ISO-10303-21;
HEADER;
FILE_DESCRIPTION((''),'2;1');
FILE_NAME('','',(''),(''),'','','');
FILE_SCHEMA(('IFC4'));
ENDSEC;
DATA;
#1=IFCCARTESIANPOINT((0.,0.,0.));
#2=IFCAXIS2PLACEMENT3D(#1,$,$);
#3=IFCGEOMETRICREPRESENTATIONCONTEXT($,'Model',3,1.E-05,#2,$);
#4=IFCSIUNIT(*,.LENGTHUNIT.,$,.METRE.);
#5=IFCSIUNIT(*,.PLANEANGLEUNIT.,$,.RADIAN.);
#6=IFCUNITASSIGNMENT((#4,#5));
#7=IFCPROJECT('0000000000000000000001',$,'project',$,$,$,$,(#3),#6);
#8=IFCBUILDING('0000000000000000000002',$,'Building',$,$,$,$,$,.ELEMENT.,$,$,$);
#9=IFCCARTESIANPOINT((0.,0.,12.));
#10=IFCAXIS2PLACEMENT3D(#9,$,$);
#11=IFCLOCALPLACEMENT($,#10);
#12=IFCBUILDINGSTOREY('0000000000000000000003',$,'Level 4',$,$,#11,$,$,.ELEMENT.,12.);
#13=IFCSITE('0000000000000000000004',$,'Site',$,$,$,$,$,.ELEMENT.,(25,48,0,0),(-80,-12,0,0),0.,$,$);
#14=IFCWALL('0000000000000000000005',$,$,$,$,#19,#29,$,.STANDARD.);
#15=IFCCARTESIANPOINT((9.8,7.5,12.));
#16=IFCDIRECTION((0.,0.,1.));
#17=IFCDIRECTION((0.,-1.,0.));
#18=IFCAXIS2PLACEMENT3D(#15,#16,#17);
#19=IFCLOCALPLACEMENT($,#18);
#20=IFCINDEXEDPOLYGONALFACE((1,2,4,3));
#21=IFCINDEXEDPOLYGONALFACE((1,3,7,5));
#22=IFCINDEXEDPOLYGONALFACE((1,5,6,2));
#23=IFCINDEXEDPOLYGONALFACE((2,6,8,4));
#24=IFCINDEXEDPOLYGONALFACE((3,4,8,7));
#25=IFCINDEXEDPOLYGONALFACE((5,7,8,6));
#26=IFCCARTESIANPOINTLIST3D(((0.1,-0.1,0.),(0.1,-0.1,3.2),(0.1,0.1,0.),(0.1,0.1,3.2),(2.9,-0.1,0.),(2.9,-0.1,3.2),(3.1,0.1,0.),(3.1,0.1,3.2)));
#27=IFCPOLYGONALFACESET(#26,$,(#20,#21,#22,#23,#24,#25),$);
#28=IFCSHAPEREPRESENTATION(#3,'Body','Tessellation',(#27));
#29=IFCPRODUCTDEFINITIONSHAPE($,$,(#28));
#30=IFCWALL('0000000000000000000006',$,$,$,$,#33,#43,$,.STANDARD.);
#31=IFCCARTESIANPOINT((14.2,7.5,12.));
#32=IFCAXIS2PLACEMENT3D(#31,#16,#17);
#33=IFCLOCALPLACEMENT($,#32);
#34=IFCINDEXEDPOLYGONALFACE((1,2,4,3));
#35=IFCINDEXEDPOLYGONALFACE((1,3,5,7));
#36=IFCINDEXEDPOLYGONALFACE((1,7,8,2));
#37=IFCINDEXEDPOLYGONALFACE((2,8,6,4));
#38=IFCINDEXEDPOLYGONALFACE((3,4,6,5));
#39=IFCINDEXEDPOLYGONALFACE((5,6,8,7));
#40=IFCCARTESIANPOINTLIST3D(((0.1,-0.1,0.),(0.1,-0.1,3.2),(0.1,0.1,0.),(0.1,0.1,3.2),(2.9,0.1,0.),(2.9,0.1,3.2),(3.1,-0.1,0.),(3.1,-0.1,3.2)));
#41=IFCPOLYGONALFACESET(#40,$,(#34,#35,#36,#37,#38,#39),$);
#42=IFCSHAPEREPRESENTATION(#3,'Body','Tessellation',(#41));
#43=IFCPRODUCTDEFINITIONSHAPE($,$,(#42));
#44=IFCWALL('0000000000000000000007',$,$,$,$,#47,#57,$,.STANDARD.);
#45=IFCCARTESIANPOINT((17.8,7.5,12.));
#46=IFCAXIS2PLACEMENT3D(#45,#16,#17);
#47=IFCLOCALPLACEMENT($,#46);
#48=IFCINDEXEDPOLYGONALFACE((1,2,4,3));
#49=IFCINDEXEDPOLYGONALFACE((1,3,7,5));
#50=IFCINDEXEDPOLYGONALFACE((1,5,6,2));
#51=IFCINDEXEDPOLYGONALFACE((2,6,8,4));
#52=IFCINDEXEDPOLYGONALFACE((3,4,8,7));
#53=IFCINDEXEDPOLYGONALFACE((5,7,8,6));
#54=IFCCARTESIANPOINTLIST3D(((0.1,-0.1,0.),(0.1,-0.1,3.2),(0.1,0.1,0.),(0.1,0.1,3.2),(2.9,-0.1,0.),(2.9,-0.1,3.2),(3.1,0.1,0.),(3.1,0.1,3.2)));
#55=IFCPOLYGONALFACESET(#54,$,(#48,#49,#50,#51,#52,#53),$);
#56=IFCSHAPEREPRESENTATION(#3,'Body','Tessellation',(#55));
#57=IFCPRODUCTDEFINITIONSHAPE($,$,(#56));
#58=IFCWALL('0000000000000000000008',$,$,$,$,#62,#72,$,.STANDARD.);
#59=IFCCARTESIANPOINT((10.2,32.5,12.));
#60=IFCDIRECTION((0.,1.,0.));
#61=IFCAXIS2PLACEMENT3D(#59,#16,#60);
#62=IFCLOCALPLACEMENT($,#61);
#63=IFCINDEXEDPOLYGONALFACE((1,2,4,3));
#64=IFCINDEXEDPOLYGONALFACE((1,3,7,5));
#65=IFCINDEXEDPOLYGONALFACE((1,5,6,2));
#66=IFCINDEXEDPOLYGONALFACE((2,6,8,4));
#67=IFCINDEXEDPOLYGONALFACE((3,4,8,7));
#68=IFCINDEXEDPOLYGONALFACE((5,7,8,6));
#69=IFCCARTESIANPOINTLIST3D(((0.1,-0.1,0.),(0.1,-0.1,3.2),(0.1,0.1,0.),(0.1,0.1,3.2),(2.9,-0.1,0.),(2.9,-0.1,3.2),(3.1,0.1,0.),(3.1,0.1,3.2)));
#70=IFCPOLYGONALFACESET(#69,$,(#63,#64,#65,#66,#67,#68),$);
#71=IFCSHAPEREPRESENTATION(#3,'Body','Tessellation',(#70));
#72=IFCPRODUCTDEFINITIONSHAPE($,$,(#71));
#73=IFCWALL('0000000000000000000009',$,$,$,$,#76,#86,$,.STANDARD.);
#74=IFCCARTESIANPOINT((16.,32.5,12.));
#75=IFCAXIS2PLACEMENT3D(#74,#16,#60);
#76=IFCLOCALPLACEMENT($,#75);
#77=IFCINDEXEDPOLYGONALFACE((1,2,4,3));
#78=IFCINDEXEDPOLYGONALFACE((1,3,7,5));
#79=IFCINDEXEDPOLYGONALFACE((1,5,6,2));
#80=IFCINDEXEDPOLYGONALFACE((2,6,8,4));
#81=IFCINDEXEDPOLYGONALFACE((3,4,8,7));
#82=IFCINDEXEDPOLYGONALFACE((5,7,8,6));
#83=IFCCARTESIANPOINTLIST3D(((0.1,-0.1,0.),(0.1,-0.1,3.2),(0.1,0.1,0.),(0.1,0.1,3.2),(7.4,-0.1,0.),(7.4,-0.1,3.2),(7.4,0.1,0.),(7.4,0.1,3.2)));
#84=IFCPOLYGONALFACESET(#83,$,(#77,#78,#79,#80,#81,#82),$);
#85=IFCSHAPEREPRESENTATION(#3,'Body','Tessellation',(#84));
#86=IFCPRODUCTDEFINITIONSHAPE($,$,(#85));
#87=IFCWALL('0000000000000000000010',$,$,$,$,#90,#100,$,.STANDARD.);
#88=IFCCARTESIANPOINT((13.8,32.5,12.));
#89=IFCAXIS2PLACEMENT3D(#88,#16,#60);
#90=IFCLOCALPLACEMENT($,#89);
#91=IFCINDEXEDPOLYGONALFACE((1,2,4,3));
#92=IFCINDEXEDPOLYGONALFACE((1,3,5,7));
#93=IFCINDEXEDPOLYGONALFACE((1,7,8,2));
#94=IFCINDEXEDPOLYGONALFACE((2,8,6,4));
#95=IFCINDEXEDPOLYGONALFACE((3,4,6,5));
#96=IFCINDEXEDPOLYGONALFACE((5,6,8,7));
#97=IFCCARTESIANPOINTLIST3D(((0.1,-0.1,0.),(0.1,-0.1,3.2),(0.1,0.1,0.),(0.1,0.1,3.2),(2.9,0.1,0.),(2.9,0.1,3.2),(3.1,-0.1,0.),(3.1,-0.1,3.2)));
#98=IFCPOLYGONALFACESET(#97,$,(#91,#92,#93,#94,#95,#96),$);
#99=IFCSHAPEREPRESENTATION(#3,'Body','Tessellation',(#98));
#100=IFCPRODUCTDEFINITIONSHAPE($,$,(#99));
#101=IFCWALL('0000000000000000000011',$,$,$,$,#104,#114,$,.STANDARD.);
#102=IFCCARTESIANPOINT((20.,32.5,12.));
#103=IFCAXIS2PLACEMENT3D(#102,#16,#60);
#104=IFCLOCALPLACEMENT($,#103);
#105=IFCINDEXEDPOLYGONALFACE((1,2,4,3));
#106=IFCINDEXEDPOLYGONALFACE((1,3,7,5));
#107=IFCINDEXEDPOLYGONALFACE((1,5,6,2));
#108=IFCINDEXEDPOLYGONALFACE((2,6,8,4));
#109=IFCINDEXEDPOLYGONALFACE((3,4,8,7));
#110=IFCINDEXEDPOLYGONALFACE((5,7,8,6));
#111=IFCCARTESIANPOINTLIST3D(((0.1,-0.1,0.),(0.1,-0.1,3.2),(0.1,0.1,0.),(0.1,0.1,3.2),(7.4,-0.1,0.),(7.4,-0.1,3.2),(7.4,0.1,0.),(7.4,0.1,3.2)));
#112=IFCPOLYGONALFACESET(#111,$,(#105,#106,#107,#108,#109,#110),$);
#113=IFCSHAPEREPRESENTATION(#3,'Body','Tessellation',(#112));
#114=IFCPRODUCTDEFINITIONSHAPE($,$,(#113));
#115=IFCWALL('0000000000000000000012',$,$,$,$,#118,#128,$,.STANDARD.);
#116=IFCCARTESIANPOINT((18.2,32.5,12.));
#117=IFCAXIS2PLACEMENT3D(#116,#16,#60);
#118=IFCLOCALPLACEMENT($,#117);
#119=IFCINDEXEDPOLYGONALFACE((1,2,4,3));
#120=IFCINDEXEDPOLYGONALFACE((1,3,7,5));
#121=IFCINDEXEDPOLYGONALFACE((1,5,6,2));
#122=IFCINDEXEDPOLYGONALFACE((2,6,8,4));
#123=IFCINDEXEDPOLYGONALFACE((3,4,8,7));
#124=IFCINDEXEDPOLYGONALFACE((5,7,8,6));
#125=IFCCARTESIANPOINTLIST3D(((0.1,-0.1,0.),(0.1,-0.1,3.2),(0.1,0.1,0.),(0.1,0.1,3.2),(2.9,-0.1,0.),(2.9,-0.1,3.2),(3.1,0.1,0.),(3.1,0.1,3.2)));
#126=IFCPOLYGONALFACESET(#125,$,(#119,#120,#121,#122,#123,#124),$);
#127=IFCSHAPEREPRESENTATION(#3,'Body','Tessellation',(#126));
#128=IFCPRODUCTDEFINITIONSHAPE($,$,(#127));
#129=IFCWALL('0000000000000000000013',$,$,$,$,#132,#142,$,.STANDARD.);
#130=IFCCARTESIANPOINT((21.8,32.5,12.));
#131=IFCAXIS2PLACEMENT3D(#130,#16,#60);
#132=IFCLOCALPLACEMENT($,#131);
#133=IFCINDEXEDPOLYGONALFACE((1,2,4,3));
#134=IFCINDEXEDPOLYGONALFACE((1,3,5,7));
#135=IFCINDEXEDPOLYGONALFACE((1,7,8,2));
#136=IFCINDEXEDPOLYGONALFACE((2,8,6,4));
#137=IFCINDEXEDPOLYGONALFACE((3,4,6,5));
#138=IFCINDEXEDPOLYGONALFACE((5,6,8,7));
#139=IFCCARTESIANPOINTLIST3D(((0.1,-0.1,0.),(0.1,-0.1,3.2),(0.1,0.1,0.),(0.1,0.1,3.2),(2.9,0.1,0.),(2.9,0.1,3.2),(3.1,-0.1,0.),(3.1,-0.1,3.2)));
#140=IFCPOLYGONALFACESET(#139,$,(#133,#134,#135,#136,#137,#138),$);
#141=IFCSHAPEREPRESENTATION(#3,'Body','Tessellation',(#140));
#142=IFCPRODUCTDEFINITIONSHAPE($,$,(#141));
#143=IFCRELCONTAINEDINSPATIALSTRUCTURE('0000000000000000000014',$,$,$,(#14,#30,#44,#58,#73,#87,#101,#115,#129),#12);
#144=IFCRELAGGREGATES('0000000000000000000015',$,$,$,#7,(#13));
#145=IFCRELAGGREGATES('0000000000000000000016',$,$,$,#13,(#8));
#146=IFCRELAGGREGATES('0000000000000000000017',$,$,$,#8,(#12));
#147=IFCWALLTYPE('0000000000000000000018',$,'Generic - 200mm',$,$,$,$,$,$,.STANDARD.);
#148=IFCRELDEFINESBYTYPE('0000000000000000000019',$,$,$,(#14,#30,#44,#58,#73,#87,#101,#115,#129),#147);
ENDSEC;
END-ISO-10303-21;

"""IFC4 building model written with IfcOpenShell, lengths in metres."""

from ifc_helpers import new_model, si_unit, frame, origin, place, context, project, spatial, polyline, outline, extrude, type_object, element, save


model = new_model("IFC4")

# Units and contexts
model_context = context("Model", 3, precision=1e-05, world=origin())
ifc_project = project(units=[si_unit("LENGTHUNIT", "METRE"), si_unit("PLANEANGLEUNIT", "RADIAN")], contexts=[model_context])

# Site, building, storey
site = spatial("IfcSite", under=ifc_project, Name="Site", CompositionType="ELEMENT", RefLatitude=(25, 48, 0, 0), RefLongitude=(-80, -12, 0, 0), RefElevation=0.0)
building = spatial("IfcBuilding", under=site, Name="Building", CompositionType="ELEMENT")
storey_placement = place(None, frame((0.0, 0.0, 12.0)))
storey = spatial("IfcBuildingStorey", under=building, at=storey_placement, Name="Level 4", CompositionType="ELEMENT", Elevation=12.0)

# Shared definitions
wall_type = type_object("IfcWallType", Name="Generic - 200mm", PredefinedType="STANDARD")

# Walls
wall_1_placement = place(None, frame((9.8, 7.5, 12.0), z_axis=(0.0, 0.0, 1.0), x_axis=(0.0, -1.0, 0.0)))
element("IfcWall", 1, at=wall_1_placement, inside=storey, type_object=wall_type, PredefinedType="STANDARD", context=model_context, shape_type="SweptSolid", body=[
    extrude(outline(polyline([(0.1, -0.1), (2.9, -0.1), (3.1, 0.1), (0.1, 0.1), (0.1, -0.1)])), origin(), (0.0, 0.0, 1.0), 3.2),
])
wall_2_placement = place(None, frame((14.2, 7.5, 12.0), z_axis=(0.0, 0.0, 1.0), x_axis=(0.0, -1.0, 0.0)))
element("IfcWall", 2, at=wall_2_placement, inside=storey, type_object=wall_type, PredefinedType="STANDARD", context=model_context, shape_type="SweptSolid", body=[
    extrude(outline(polyline([(0.1, -0.1), (3.1, -0.1), (2.9, 0.1), (0.1, 0.1), (0.1, -0.1)])), origin(), (0.0, 0.0, 1.0), 3.2),
])
wall_3_placement = place(None, frame((17.8, 7.5, 12.0), z_axis=(0.0, 0.0, 1.0), x_axis=(0.0, -1.0, 0.0)))
element("IfcWall", 3, at=wall_3_placement, inside=storey, type_object=wall_type, PredefinedType="STANDARD", context=model_context, shape_type="SweptSolid", body=[
    extrude(outline(polyline([(0.1, -0.1), (2.9, -0.1), (3.1, 0.1), (0.1, 0.1), (0.1, -0.1)])), origin(), (0.0, 0.0, 1.0), 3.2),
])
wall_4_placement = place(None, frame((10.2, 32.5, 12.0), z_axis=(0.0, 0.0, 1.0), x_axis=(0.0, 1.0, 0.0)))
element("IfcWall", 4, at=wall_4_placement, inside=storey, type_object=wall_type, PredefinedType="STANDARD", context=model_context, shape_type="SweptSolid", body=[
    extrude(outline(polyline([(0.1, -0.1), (2.9, -0.1), (3.1, 0.1), (0.1, 0.1), (0.1, -0.1)])), origin(), (0.0, 0.0, 1.0), 3.2),
])
wall_5_placement = place(None, frame((16.0, 32.5, 12.0), z_axis=(0.0, 0.0, 1.0), x_axis=(0.0, 1.0, 0.0)))
element("IfcWall", 5, at=wall_5_placement, inside=storey, type_object=wall_type, PredefinedType="STANDARD", context=model_context, shape_type="SweptSolid", body=[
    extrude(outline(polyline([(0.1, -0.1), (7.4, -0.1), (7.4, 0.1), (0.1, 0.1), (0.1, -0.1)])), origin(), (0.0, 0.0, 1.0), 3.2),
])
wall_6_placement = place(None, frame((13.8, 32.5, 12.0), z_axis=(0.0, 0.0, 1.0), x_axis=(0.0, 1.0, 0.0)))
element("IfcWall", 6, at=wall_6_placement, inside=storey, type_object=wall_type, PredefinedType="STANDARD", context=model_context, shape_type="SweptSolid", body=[
    extrude(outline(polyline([(0.1, -0.1), (3.1, -0.1), (2.9, 0.1), (0.1, 0.1), (0.1, -0.1)])), origin(), (0.0, 0.0, 1.0), 3.2),
])
wall_7_placement = place(None, frame((20.0, 32.5, 12.0), z_axis=(0.0, 0.0, 1.0), x_axis=(0.0, 1.0, 0.0)))
element("IfcWall", 7, at=wall_7_placement, inside=storey, type_object=wall_type, PredefinedType="STANDARD", context=model_context, shape_type="SweptSolid", body=[
    extrude(outline(polyline([(0.1, -0.1), (7.4, -0.1), (7.4, 0.1), (0.1, 0.1), (0.1, -0.1)])), origin(), (0.0, 0.0, 1.0), 3.2),
])
wall_8_placement = place(None, frame((18.2, 32.5, 12.0), z_axis=(0.0, 0.0, 1.0), x_axis=(0.0, 1.0, 0.0)))
element("IfcWall", 8, at=wall_8_placement, inside=storey, type_object=wall_type, PredefinedType="STANDARD", context=model_context, shape_type="SweptSolid", body=[
    extrude(outline(polyline([(0.1, -0.1), (2.9, -0.1), (3.1, 0.1), (0.1, 0.1), (0.1, -0.1)])), origin(), (0.0, 0.0, 1.0), 3.2),
])
wall_9_placement = place(None, frame((21.8, 32.5, 12.0), z_axis=(0.0, 0.0, 1.0), x_axis=(0.0, 1.0, 0.0)))
element("IfcWall", 9, at=wall_9_placement, inside=storey, type_object=wall_type, PredefinedType="STANDARD", context=model_context, shape_type="SweptSolid", body=[
    extrude(outline(polyline([(0.1, -0.1), (3.1, -0.1), (2.9, 0.1), (0.1, 0.1), (0.1, -0.1)])), origin(), (0.0, 0.0, 1.0), 3.2),
])

save(model, "model.ifc")
